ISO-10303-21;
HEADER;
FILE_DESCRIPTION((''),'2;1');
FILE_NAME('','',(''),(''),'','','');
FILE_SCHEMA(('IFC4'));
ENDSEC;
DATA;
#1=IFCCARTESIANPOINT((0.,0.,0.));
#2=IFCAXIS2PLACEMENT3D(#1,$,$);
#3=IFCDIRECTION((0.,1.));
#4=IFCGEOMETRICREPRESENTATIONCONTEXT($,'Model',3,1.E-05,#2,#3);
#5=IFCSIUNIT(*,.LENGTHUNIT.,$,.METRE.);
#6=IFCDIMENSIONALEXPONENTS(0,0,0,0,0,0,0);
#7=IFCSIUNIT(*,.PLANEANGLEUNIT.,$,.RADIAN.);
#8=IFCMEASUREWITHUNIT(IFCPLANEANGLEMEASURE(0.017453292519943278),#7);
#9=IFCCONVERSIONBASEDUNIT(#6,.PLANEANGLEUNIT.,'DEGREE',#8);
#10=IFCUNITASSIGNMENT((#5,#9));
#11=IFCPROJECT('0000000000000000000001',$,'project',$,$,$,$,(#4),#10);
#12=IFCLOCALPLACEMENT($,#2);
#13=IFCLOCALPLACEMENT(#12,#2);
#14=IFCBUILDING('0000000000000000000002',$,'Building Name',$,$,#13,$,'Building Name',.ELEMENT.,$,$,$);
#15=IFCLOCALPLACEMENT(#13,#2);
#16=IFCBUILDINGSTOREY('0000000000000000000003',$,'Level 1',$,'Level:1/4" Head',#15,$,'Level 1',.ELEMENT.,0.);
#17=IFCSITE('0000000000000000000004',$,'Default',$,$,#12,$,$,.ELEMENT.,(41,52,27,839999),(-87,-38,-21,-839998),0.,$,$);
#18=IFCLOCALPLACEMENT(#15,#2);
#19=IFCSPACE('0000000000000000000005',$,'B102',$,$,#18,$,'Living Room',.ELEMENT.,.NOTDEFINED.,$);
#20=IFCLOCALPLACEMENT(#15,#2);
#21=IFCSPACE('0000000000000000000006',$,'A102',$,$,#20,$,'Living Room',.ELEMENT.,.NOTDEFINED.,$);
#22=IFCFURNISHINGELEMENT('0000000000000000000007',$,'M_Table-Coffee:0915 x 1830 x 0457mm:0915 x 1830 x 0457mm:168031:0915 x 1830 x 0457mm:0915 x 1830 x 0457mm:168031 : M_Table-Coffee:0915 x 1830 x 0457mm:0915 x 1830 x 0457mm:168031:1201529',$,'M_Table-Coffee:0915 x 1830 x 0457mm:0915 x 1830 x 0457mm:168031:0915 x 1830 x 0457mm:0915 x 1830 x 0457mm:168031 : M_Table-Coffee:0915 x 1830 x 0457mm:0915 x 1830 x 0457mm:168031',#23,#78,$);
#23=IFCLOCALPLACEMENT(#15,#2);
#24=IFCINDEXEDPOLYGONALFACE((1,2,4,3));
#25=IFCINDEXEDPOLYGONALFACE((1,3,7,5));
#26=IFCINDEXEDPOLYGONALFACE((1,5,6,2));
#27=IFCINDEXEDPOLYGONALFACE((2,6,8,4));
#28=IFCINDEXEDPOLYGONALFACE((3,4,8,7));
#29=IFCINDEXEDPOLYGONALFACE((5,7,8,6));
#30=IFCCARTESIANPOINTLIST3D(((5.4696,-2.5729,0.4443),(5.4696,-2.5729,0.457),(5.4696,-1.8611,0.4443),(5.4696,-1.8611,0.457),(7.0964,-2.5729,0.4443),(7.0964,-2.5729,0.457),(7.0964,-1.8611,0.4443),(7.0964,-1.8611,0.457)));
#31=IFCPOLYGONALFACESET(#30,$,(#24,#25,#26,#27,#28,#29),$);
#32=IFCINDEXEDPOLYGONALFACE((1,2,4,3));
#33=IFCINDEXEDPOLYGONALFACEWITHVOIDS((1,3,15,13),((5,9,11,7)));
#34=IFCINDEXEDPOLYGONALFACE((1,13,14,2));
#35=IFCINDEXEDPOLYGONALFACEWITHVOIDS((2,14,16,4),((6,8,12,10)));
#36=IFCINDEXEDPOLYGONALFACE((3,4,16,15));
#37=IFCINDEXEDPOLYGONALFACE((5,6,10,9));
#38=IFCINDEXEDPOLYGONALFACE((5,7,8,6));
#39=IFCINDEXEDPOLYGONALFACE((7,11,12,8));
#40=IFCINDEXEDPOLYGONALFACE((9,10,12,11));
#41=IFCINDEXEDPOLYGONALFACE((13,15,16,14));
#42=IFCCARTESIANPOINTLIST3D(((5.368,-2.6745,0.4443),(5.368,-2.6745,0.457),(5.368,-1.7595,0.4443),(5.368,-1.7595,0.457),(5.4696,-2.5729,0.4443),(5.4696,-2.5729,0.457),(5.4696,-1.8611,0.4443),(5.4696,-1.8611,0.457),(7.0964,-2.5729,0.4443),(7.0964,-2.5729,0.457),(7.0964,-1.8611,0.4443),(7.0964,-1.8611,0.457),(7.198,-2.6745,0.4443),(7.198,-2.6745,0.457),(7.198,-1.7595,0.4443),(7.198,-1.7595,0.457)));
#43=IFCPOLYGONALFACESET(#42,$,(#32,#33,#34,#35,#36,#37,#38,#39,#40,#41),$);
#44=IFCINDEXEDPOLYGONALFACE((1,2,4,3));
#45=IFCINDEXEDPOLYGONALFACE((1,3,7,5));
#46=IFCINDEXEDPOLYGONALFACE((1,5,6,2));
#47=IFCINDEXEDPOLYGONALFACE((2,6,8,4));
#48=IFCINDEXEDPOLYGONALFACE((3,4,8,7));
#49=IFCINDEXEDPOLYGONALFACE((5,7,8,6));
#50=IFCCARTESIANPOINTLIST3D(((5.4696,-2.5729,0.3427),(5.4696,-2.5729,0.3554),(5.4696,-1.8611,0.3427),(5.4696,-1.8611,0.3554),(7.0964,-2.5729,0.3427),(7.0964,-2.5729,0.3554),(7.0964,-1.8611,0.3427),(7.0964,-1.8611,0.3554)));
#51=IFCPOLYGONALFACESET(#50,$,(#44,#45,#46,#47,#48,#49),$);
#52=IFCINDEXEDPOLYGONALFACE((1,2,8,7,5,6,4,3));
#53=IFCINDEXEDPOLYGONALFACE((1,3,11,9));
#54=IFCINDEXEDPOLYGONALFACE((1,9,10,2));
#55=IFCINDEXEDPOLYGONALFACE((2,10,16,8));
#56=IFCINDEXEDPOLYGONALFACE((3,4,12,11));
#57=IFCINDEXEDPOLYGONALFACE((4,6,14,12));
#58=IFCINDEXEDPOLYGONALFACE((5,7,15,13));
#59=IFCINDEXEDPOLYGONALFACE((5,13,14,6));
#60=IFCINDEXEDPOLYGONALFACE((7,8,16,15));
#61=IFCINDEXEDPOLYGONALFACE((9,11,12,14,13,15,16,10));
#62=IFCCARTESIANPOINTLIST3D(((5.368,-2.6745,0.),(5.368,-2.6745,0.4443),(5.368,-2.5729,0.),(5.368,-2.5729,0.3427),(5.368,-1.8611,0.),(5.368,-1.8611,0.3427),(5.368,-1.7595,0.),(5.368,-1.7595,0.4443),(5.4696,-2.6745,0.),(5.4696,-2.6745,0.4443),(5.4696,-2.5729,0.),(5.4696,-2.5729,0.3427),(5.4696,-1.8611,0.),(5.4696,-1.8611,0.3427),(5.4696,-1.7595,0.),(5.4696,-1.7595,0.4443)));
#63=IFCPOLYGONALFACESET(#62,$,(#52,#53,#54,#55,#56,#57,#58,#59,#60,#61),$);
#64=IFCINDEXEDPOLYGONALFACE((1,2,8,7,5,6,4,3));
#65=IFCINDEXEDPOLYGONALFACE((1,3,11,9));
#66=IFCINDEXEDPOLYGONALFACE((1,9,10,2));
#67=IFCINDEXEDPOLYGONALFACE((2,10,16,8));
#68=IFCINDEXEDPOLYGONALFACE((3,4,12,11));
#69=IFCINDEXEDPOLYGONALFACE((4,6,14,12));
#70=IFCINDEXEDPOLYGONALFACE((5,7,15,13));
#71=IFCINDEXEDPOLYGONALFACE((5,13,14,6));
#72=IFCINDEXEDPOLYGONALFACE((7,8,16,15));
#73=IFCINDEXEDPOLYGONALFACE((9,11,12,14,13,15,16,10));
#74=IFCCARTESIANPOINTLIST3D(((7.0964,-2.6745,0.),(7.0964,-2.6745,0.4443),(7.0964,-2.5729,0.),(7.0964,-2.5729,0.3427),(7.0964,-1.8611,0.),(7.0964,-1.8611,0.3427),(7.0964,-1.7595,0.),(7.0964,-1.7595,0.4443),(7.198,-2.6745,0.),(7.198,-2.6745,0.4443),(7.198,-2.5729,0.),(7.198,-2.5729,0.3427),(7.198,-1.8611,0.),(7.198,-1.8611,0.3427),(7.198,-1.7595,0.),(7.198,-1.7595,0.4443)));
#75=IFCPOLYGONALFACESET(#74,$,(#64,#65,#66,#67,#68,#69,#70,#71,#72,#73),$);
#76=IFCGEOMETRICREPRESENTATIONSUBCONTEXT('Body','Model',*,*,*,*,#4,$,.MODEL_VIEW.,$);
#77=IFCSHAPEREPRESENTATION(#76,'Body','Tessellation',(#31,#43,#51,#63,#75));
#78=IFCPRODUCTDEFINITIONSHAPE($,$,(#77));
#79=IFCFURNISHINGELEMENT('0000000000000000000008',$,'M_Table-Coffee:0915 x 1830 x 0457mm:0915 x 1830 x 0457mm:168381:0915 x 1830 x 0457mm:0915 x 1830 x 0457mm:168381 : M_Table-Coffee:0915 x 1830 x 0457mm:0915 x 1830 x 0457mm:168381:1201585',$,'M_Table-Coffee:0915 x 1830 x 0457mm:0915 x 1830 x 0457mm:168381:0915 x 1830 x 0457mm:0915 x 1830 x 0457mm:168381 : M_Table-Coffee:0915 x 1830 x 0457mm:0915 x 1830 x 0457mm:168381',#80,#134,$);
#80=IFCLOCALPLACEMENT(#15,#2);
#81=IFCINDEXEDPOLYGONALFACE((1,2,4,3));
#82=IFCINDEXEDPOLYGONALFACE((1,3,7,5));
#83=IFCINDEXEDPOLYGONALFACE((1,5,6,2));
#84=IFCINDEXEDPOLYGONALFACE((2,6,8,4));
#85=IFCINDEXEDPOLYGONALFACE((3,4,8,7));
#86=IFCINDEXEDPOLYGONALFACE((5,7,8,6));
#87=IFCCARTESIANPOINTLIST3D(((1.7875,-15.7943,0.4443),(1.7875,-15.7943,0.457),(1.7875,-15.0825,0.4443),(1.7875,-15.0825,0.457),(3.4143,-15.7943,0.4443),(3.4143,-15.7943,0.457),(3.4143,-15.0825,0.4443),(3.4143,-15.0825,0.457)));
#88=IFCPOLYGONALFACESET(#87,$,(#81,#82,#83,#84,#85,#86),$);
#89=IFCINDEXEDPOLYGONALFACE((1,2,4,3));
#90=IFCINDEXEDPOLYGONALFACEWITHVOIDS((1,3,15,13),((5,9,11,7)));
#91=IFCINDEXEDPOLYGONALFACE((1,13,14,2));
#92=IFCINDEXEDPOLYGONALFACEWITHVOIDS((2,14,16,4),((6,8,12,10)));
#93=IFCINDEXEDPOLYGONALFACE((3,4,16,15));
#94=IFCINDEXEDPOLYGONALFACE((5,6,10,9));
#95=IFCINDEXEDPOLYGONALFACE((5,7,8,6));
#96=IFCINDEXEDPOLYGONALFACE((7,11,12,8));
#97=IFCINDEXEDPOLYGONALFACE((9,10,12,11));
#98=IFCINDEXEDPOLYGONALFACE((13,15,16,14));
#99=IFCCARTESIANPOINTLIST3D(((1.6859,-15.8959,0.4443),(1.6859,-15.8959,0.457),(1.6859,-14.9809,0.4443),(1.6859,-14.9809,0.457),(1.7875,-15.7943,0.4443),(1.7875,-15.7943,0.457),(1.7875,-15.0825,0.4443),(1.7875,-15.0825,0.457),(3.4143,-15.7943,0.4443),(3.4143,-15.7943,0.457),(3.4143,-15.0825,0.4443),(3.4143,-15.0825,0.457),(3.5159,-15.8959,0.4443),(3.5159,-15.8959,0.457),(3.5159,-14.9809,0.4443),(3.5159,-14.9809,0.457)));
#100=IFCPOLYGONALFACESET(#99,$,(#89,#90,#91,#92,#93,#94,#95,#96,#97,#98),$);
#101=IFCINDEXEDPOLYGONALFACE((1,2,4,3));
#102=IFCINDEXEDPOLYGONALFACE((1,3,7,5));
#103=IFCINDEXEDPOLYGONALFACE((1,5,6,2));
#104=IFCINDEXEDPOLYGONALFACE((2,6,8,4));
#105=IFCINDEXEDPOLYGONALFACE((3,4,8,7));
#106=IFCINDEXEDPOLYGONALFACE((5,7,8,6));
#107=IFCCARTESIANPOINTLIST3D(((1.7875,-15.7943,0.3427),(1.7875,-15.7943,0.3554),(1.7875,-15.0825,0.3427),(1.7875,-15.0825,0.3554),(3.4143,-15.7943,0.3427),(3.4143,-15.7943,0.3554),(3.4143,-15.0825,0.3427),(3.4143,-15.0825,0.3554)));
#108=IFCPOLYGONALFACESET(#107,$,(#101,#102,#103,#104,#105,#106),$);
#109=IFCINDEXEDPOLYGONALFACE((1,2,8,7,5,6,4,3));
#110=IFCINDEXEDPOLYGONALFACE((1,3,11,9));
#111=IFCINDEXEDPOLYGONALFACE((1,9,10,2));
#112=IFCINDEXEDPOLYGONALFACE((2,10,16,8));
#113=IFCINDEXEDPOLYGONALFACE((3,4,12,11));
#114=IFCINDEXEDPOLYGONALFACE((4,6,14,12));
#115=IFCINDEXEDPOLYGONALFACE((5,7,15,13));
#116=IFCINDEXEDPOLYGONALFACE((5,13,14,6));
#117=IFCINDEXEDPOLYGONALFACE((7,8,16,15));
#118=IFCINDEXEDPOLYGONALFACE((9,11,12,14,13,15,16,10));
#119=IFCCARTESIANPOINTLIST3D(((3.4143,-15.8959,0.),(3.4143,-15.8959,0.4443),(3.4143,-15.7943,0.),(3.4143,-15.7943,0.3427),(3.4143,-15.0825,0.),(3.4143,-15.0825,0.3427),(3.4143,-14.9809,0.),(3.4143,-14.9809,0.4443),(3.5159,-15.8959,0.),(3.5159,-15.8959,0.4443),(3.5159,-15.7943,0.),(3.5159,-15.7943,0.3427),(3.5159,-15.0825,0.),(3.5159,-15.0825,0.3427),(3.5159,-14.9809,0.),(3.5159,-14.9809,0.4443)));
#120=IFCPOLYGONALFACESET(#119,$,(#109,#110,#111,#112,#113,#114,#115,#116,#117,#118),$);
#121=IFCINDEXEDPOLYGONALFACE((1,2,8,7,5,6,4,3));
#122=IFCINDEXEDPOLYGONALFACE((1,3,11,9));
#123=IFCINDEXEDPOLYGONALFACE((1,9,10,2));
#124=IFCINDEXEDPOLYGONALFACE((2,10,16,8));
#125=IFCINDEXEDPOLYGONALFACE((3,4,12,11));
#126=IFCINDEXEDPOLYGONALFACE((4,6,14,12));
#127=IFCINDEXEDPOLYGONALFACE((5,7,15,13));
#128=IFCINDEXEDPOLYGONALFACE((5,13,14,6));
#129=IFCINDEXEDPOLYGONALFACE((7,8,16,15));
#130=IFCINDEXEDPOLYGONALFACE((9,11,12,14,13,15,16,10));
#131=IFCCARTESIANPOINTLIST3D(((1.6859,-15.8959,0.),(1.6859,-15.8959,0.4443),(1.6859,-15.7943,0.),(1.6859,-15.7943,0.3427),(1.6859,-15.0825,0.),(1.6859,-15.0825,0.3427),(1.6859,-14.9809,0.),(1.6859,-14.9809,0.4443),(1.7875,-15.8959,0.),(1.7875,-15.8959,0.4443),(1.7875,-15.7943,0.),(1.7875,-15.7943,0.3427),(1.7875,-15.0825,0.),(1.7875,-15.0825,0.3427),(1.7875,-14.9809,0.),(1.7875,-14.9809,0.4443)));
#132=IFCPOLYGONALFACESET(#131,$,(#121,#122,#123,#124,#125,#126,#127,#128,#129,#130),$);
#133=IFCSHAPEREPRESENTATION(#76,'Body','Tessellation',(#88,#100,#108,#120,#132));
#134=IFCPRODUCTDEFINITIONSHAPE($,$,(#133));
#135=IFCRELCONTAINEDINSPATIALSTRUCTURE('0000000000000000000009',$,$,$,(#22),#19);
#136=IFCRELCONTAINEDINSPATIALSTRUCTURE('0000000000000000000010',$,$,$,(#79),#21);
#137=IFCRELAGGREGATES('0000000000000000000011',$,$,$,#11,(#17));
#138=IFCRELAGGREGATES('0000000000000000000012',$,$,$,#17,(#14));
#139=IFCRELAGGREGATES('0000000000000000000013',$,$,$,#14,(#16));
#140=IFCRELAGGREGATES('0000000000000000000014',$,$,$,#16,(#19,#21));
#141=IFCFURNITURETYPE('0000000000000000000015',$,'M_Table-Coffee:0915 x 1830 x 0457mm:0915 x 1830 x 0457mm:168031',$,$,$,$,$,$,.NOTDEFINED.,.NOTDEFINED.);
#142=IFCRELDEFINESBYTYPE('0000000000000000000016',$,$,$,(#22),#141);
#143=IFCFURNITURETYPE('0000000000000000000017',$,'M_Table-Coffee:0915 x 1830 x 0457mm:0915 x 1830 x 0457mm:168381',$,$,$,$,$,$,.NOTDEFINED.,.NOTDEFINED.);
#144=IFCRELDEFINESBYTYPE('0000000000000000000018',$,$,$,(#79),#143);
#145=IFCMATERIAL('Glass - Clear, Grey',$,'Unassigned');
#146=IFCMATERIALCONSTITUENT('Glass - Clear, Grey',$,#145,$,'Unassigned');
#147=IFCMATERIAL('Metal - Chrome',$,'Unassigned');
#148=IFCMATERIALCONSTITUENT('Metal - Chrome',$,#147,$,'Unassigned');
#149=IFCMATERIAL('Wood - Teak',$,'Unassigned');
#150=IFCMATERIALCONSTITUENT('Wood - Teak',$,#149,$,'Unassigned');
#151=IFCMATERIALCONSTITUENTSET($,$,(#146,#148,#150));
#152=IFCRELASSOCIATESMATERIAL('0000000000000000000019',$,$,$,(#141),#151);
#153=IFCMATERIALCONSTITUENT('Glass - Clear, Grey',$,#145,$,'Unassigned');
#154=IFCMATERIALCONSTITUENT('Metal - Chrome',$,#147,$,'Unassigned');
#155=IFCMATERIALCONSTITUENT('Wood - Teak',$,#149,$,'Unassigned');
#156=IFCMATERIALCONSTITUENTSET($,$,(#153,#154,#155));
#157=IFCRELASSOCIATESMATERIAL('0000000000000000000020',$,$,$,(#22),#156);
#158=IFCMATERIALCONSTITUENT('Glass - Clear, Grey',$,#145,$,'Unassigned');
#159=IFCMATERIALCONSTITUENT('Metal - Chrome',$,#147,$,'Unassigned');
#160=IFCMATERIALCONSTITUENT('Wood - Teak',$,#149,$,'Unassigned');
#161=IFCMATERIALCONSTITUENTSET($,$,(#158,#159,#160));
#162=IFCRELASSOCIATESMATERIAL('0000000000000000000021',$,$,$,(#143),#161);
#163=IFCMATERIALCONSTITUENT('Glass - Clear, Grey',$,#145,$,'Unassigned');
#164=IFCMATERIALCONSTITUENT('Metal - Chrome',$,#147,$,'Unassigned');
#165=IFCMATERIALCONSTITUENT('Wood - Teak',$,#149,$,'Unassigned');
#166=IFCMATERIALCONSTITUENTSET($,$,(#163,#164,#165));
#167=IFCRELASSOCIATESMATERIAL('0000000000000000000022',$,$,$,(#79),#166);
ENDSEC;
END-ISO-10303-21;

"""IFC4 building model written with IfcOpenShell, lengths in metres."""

from ifc_helpers import new_model, entity, si_unit, converted_unit, direction, frame, origin, place, context, subcontext, project, spatial, indexed_curve, outline, extrude, source, transform, mapped, material, constituent, constituent_set, type_object, type_shapes, element, save


model = new_model("IFC4")

# Units and contexts
model_context = context("Model", 3, precision=1e-05, world=origin(), true_north=direction((0.0, 1.0)))
body_context = subcontext(model_context, "Body", "Model", "MODEL_VIEW")
ifc_project = project(units=[si_unit("LENGTHUNIT", "METRE"), converted_unit("PLANEANGLEUNIT", "DEGREE", entity("IfcPlaneAngleMeasure", 0.017453292519943278), si_unit("PLANEANGLEUNIT", "RADIAN"), dimensions=[0, 0, 0, 0, 0, 0, 0])], contexts=[model_context])

# Site, building, storey
site_placement = place(None, origin())
site = spatial("IfcSite", under=ifc_project, at=site_placement, Name="Default", CompositionType="ELEMENT", RefLatitude=(41, 52, 27, 839999), RefLongitude=(-87, -38, -21, -839998), RefElevation=0.0)
building_placement = place(site_placement, origin())
building = spatial("IfcBuilding", under=site, at=building_placement, Name="Building Name", LongName="Building Name", CompositionType="ELEMENT")
storey_placement = place(building_placement, origin())
storey = spatial("IfcBuildingStorey", under=building, at=storey_placement, Name="Level 1", ObjectType="Level:1/4\" Head", LongName="Level 1", CompositionType="ELEMENT", Elevation=0.0)

# Shared definitions
space_1_placement = place(storey_placement, origin())
space_1 = spatial("IfcSpace", under=storey, at=space_1_placement, Name="B102", LongName="Living Room", CompositionType="ELEMENT", PredefinedType="NOTDEFINED")

# Furnishing element
ifc_material_1 = material(Name="Glass - Clear, Grey", Category="Unassigned")
ifc_material_2 = material(Name="Wood - Teak", Category="Unassigned")
ifc_material_3 = material(Name="Metal - Chrome", Category="Unassigned")
ifc_constituent_1 = constituent(ifc_material_1, Name="Glass - Clear, Grey", Category="Unassigned")
ifc_constituent_2 = constituent(ifc_material_3, Name="Metal - Chrome", Category="Unassigned")
ifc_constituent_3 = constituent(ifc_material_2, Name="Wood - Teak", Category="Unassigned")
ifc_constituent_set_1 = constituent_set(constituents=[ifc_constituent_1, ifc_constituent_2, ifc_constituent_3])
ifc_constituent_4 = constituent(ifc_material_1, Name="Glass - Clear, Grey", Category="Unassigned")
ifc_constituent_5 = constituent(ifc_material_3, Name="Metal - Chrome", Category="Unassigned")
ifc_constituent_6 = constituent(ifc_material_2, Name="Wood - Teak", Category="Unassigned")
ifc_constituent_set_2 = constituent_set(constituents=[ifc_constituent_4, ifc_constituent_5, ifc_constituent_6])
furniture_type_1 = type_object("IfcFurnitureType", Name="M_Table-Coffee:0915 x 1830 x 0457mm:0915 x 1830 x 0457mm:168031", AssemblyPlace="NOTDEFINED", PredefinedType="NOTDEFINED", material=ifc_constituent_set_2)
shared_shape_1 = source(origin(), body_context, "Body", "SweptSolid", [
    extrude(outline(indexed_curve([(-0.3559, -0.8134), (0.3559, -0.8134), (0.3559, 0.8134), (-0.3559, 0.8134), (-0.3559, -0.8134)], self_intersect=False)), frame((6.283, -2.217, 0.4443), z_axis=(0.0, 0.0, 1.0), x_axis=(0.0, -1.0, 0.0)), (0.0, 0.0, 1.0), 0.0127),
    extrude(outline(indexed_curve([(-0.4575, -0.915), (0.4575, -0.915), (0.4575, 0.915), (-0.4575, 0.915), (-0.4575, -0.915)], self_intersect=False), holes=[indexed_curve([(0.3559, 0.8134), (0.3559, -0.8134), (-0.3559, -0.8134), (-0.3559, 0.8134), (0.3559, 0.8134)], self_intersect=False)]), frame((6.283, -2.217, 0.4443), z_axis=(0.0, 0.0, 1.0), x_axis=(0.0, -1.0, 0.0)), (0.0, 0.0, 1.0), 0.0127),
    extrude(outline(indexed_curve([(-0.3559, -0.8134), (0.3559, -0.8134), (0.3559, 0.8134), (-0.3559, 0.8134), (-0.3559, -0.8134)], self_intersect=False)), frame((6.283, -2.217, 0.3427), z_axis=(0.0, 0.0, 1.0), x_axis=(0.0, -1.0, 0.0)), (0.0, 0.0, 1.0), 0.0127),
    extrude(outline(indexed_curve([(-0.2476, -0.4575), (0.1968, -0.4575), (0.1968, -0.3559), (-0.1459, -0.3559), (-0.1459, 0.3559), (0.1968, 0.3559), (0.1968, 0.4575), (-0.2476, 0.4575), (-0.2476, -0.4575)], self_intersect=False)), frame((5.368, -2.217, 0.1968), z_axis=(1.0, 0.0, 0.0), x_axis=(0.0, 0.0, -1.0)), (0.0, 0.0, 1.0), 0.1016),
    extrude(outline(indexed_curve([(-0.4575, -0.2475), (0.4575, -0.2475), (0.4575, 0.1967), (0.3559, 0.1967), (0.3559, -0.146), (-0.3559, -0.146), (-0.3559, 0.1967), (-0.4575, 0.1967), (-0.4575, -0.2475)], self_intersect=False)), frame((7.0964, -2.217, 0.1967), z_axis=(1.0, 0.0, 0.0), x_axis=(0.0, -1.0, 0.0)), (0.0, 0.0, 1.0), 0.1016),
])
type_shapes(furniture_type_1, [shared_shape_1])
furnishing_1_placement = place(space_1_placement, origin())
element("IfcFurnishingElement", 1, at=furnishing_1_placement, inside=space_1, type_object=furniture_type_1, material=ifc_constituent_set_1, Name="M_Table-Coffee:0915 x 1830 x 0457mm:0915 x 1830 x 0457mm:168031:0915 x 1830 x 0457mm:0915 x 1830 x 0457mm:168031 : M_Table-Coffee:0915 x 1830 x 0457mm:0915 x 1830 x 0457mm:168031:1201529", ObjectType="M_Table-Coffee:0915 x 1830 x 0457mm:0915 x 1830 x 0457mm:168031:0915 x 1830 x 0457mm:0915 x 1830 x 0457mm:168031 : M_Table-Coffee:0915 x 1830 x 0457mm:0915 x 1830 x 0457mm:168031", context=body_context, shape_type="MappedRepresentation", body=[
    mapped(shared_shape_1, transform((0.0, 0.0, 0.0), scale=1.0)),
])

# Shared definitions
space_2_placement = place(storey_placement, origin())
space_2 = spatial("IfcSpace", under=storey, at=space_2_placement, Name="A102", LongName="Living Room", CompositionType="ELEMENT", PredefinedType="NOTDEFINED")

# Furnishing element
ifc_constituent_7 = constituent(ifc_material_1, Name="Glass - Clear, Grey", Category="Unassigned")
ifc_constituent_8 = constituent(ifc_material_3, Name="Metal - Chrome", Category="Unassigned")
ifc_constituent_9 = constituent(ifc_material_2, Name="Wood - Teak", Category="Unassigned")
ifc_constituent_set_3 = constituent_set(constituents=[ifc_constituent_7, ifc_constituent_8, ifc_constituent_9])
ifc_constituent_10 = constituent(ifc_material_1, Name="Glass - Clear, Grey", Category="Unassigned")
ifc_constituent_11 = constituent(ifc_material_3, Name="Metal - Chrome", Category="Unassigned")
ifc_constituent_12 = constituent(ifc_material_2, Name="Wood - Teak", Category="Unassigned")
ifc_constituent_set_4 = constituent_set(constituents=[ifc_constituent_10, ifc_constituent_11, ifc_constituent_12])
furniture_type_2 = type_object("IfcFurnitureType", Name="M_Table-Coffee:0915 x 1830 x 0457mm:0915 x 1830 x 0457mm:168381", AssemblyPlace="NOTDEFINED", PredefinedType="NOTDEFINED", material=ifc_constituent_set_4)
shared_shape_2 = source(origin(), body_context, "Body", "SweptSolid", [
    extrude(outline(indexed_curve([(-0.3559, -0.8134), (0.3559, -0.8134), (0.3559, 0.8134), (-0.3559, 0.8134), (-0.3559, -0.8134)], self_intersect=False)), frame((2.6009, -15.4384, 0.4443), z_axis=(0.0, 0.0, 1.0), x_axis=(0.0, 1.0, 0.0)), (0.0, 0.0, 1.0), 0.0127),
    extrude(outline(indexed_curve([(-0.4575, -0.915), (0.4575, -0.915), (0.4575, 0.915), (-0.4575, 0.915), (-0.4575, -0.915)], self_intersect=False), holes=[indexed_curve([(0.3559, 0.8134), (0.3559, -0.8134), (-0.3559, -0.8134), (-0.3559, 0.8134), (0.3559, 0.8134)], self_intersect=False)]), frame((2.6009, -15.4384, 0.4443), z_axis=(0.0, 0.0, 1.0), x_axis=(0.0, 1.0, 0.0)), (0.0, 0.0, 1.0), 0.0127),
    extrude(outline(indexed_curve([(-0.3559, -0.8134), (0.3559, -0.8134), (0.3559, 0.8134), (-0.3559, 0.8134), (-0.3559, -0.8134)], self_intersect=False)), frame((2.6009, -15.4384, 0.3427), z_axis=(0.0, 0.0, 1.0), x_axis=(0.0, 1.0, 0.0)), (0.0, 0.0, 1.0), 0.0127),
    extrude(outline(indexed_curve([(-0.4575, -0.2476), (0.4575, -0.2476), (0.4575, 0.1968), (0.3559, 0.1968), (0.3559, -0.1459), (-0.3559, -0.1459), (-0.3559, 0.1968), (-0.4575, 0.1968), (-0.4575, -0.2476)], self_intersect=False)), frame((3.4143, -15.4384, 0.1968), z_axis=(1.0, 0.0, 0.0), x_axis=(0.0, -1.0, 0.0)), (0.0, 0.0, 1.0), 0.1016),
    extrude(outline(indexed_curve([(-0.2475, -0.4575), (0.1967, -0.4575), (0.1967, -0.3559), (-0.146, -0.3559), (-0.146, 0.3559), (0.1967, 0.3559), (0.1967, 0.4575), (-0.2475, 0.4575), (-0.2475, -0.4575)], self_intersect=False)), frame((1.6859, -15.4384, 0.1967), z_axis=(1.0, 0.0, 0.0), x_axis=(0.0, 0.0, -1.0)), (0.0, 0.0, 1.0), 0.1016),
])
type_shapes(furniture_type_2, [shared_shape_2])
furnishing_2_placement = place(space_2_placement, origin())
element("IfcFurnishingElement", 2, at=furnishing_2_placement, inside=space_2, type_object=furniture_type_2, material=ifc_constituent_set_3, Name="M_Table-Coffee:0915 x 1830 x 0457mm:0915 x 1830 x 0457mm:168381:0915 x 1830 x 0457mm:0915 x 1830 x 0457mm:168381 : M_Table-Coffee:0915 x 1830 x 0457mm:0915 x 1830 x 0457mm:168381:1201585", ObjectType="M_Table-Coffee:0915 x 1830 x 0457mm:0915 x 1830 x 0457mm:168381:0915 x 1830 x 0457mm:0915 x 1830 x 0457mm:168381 : M_Table-Coffee:0915 x 1830 x 0457mm:0915 x 1830 x 0457mm:168381", context=body_context, shape_type="MappedRepresentation", body=[
    mapped(shared_shape_2, transform((0.0, 0.0, 0.0), scale=1.0)),
])

save(model, "model.ifc")
